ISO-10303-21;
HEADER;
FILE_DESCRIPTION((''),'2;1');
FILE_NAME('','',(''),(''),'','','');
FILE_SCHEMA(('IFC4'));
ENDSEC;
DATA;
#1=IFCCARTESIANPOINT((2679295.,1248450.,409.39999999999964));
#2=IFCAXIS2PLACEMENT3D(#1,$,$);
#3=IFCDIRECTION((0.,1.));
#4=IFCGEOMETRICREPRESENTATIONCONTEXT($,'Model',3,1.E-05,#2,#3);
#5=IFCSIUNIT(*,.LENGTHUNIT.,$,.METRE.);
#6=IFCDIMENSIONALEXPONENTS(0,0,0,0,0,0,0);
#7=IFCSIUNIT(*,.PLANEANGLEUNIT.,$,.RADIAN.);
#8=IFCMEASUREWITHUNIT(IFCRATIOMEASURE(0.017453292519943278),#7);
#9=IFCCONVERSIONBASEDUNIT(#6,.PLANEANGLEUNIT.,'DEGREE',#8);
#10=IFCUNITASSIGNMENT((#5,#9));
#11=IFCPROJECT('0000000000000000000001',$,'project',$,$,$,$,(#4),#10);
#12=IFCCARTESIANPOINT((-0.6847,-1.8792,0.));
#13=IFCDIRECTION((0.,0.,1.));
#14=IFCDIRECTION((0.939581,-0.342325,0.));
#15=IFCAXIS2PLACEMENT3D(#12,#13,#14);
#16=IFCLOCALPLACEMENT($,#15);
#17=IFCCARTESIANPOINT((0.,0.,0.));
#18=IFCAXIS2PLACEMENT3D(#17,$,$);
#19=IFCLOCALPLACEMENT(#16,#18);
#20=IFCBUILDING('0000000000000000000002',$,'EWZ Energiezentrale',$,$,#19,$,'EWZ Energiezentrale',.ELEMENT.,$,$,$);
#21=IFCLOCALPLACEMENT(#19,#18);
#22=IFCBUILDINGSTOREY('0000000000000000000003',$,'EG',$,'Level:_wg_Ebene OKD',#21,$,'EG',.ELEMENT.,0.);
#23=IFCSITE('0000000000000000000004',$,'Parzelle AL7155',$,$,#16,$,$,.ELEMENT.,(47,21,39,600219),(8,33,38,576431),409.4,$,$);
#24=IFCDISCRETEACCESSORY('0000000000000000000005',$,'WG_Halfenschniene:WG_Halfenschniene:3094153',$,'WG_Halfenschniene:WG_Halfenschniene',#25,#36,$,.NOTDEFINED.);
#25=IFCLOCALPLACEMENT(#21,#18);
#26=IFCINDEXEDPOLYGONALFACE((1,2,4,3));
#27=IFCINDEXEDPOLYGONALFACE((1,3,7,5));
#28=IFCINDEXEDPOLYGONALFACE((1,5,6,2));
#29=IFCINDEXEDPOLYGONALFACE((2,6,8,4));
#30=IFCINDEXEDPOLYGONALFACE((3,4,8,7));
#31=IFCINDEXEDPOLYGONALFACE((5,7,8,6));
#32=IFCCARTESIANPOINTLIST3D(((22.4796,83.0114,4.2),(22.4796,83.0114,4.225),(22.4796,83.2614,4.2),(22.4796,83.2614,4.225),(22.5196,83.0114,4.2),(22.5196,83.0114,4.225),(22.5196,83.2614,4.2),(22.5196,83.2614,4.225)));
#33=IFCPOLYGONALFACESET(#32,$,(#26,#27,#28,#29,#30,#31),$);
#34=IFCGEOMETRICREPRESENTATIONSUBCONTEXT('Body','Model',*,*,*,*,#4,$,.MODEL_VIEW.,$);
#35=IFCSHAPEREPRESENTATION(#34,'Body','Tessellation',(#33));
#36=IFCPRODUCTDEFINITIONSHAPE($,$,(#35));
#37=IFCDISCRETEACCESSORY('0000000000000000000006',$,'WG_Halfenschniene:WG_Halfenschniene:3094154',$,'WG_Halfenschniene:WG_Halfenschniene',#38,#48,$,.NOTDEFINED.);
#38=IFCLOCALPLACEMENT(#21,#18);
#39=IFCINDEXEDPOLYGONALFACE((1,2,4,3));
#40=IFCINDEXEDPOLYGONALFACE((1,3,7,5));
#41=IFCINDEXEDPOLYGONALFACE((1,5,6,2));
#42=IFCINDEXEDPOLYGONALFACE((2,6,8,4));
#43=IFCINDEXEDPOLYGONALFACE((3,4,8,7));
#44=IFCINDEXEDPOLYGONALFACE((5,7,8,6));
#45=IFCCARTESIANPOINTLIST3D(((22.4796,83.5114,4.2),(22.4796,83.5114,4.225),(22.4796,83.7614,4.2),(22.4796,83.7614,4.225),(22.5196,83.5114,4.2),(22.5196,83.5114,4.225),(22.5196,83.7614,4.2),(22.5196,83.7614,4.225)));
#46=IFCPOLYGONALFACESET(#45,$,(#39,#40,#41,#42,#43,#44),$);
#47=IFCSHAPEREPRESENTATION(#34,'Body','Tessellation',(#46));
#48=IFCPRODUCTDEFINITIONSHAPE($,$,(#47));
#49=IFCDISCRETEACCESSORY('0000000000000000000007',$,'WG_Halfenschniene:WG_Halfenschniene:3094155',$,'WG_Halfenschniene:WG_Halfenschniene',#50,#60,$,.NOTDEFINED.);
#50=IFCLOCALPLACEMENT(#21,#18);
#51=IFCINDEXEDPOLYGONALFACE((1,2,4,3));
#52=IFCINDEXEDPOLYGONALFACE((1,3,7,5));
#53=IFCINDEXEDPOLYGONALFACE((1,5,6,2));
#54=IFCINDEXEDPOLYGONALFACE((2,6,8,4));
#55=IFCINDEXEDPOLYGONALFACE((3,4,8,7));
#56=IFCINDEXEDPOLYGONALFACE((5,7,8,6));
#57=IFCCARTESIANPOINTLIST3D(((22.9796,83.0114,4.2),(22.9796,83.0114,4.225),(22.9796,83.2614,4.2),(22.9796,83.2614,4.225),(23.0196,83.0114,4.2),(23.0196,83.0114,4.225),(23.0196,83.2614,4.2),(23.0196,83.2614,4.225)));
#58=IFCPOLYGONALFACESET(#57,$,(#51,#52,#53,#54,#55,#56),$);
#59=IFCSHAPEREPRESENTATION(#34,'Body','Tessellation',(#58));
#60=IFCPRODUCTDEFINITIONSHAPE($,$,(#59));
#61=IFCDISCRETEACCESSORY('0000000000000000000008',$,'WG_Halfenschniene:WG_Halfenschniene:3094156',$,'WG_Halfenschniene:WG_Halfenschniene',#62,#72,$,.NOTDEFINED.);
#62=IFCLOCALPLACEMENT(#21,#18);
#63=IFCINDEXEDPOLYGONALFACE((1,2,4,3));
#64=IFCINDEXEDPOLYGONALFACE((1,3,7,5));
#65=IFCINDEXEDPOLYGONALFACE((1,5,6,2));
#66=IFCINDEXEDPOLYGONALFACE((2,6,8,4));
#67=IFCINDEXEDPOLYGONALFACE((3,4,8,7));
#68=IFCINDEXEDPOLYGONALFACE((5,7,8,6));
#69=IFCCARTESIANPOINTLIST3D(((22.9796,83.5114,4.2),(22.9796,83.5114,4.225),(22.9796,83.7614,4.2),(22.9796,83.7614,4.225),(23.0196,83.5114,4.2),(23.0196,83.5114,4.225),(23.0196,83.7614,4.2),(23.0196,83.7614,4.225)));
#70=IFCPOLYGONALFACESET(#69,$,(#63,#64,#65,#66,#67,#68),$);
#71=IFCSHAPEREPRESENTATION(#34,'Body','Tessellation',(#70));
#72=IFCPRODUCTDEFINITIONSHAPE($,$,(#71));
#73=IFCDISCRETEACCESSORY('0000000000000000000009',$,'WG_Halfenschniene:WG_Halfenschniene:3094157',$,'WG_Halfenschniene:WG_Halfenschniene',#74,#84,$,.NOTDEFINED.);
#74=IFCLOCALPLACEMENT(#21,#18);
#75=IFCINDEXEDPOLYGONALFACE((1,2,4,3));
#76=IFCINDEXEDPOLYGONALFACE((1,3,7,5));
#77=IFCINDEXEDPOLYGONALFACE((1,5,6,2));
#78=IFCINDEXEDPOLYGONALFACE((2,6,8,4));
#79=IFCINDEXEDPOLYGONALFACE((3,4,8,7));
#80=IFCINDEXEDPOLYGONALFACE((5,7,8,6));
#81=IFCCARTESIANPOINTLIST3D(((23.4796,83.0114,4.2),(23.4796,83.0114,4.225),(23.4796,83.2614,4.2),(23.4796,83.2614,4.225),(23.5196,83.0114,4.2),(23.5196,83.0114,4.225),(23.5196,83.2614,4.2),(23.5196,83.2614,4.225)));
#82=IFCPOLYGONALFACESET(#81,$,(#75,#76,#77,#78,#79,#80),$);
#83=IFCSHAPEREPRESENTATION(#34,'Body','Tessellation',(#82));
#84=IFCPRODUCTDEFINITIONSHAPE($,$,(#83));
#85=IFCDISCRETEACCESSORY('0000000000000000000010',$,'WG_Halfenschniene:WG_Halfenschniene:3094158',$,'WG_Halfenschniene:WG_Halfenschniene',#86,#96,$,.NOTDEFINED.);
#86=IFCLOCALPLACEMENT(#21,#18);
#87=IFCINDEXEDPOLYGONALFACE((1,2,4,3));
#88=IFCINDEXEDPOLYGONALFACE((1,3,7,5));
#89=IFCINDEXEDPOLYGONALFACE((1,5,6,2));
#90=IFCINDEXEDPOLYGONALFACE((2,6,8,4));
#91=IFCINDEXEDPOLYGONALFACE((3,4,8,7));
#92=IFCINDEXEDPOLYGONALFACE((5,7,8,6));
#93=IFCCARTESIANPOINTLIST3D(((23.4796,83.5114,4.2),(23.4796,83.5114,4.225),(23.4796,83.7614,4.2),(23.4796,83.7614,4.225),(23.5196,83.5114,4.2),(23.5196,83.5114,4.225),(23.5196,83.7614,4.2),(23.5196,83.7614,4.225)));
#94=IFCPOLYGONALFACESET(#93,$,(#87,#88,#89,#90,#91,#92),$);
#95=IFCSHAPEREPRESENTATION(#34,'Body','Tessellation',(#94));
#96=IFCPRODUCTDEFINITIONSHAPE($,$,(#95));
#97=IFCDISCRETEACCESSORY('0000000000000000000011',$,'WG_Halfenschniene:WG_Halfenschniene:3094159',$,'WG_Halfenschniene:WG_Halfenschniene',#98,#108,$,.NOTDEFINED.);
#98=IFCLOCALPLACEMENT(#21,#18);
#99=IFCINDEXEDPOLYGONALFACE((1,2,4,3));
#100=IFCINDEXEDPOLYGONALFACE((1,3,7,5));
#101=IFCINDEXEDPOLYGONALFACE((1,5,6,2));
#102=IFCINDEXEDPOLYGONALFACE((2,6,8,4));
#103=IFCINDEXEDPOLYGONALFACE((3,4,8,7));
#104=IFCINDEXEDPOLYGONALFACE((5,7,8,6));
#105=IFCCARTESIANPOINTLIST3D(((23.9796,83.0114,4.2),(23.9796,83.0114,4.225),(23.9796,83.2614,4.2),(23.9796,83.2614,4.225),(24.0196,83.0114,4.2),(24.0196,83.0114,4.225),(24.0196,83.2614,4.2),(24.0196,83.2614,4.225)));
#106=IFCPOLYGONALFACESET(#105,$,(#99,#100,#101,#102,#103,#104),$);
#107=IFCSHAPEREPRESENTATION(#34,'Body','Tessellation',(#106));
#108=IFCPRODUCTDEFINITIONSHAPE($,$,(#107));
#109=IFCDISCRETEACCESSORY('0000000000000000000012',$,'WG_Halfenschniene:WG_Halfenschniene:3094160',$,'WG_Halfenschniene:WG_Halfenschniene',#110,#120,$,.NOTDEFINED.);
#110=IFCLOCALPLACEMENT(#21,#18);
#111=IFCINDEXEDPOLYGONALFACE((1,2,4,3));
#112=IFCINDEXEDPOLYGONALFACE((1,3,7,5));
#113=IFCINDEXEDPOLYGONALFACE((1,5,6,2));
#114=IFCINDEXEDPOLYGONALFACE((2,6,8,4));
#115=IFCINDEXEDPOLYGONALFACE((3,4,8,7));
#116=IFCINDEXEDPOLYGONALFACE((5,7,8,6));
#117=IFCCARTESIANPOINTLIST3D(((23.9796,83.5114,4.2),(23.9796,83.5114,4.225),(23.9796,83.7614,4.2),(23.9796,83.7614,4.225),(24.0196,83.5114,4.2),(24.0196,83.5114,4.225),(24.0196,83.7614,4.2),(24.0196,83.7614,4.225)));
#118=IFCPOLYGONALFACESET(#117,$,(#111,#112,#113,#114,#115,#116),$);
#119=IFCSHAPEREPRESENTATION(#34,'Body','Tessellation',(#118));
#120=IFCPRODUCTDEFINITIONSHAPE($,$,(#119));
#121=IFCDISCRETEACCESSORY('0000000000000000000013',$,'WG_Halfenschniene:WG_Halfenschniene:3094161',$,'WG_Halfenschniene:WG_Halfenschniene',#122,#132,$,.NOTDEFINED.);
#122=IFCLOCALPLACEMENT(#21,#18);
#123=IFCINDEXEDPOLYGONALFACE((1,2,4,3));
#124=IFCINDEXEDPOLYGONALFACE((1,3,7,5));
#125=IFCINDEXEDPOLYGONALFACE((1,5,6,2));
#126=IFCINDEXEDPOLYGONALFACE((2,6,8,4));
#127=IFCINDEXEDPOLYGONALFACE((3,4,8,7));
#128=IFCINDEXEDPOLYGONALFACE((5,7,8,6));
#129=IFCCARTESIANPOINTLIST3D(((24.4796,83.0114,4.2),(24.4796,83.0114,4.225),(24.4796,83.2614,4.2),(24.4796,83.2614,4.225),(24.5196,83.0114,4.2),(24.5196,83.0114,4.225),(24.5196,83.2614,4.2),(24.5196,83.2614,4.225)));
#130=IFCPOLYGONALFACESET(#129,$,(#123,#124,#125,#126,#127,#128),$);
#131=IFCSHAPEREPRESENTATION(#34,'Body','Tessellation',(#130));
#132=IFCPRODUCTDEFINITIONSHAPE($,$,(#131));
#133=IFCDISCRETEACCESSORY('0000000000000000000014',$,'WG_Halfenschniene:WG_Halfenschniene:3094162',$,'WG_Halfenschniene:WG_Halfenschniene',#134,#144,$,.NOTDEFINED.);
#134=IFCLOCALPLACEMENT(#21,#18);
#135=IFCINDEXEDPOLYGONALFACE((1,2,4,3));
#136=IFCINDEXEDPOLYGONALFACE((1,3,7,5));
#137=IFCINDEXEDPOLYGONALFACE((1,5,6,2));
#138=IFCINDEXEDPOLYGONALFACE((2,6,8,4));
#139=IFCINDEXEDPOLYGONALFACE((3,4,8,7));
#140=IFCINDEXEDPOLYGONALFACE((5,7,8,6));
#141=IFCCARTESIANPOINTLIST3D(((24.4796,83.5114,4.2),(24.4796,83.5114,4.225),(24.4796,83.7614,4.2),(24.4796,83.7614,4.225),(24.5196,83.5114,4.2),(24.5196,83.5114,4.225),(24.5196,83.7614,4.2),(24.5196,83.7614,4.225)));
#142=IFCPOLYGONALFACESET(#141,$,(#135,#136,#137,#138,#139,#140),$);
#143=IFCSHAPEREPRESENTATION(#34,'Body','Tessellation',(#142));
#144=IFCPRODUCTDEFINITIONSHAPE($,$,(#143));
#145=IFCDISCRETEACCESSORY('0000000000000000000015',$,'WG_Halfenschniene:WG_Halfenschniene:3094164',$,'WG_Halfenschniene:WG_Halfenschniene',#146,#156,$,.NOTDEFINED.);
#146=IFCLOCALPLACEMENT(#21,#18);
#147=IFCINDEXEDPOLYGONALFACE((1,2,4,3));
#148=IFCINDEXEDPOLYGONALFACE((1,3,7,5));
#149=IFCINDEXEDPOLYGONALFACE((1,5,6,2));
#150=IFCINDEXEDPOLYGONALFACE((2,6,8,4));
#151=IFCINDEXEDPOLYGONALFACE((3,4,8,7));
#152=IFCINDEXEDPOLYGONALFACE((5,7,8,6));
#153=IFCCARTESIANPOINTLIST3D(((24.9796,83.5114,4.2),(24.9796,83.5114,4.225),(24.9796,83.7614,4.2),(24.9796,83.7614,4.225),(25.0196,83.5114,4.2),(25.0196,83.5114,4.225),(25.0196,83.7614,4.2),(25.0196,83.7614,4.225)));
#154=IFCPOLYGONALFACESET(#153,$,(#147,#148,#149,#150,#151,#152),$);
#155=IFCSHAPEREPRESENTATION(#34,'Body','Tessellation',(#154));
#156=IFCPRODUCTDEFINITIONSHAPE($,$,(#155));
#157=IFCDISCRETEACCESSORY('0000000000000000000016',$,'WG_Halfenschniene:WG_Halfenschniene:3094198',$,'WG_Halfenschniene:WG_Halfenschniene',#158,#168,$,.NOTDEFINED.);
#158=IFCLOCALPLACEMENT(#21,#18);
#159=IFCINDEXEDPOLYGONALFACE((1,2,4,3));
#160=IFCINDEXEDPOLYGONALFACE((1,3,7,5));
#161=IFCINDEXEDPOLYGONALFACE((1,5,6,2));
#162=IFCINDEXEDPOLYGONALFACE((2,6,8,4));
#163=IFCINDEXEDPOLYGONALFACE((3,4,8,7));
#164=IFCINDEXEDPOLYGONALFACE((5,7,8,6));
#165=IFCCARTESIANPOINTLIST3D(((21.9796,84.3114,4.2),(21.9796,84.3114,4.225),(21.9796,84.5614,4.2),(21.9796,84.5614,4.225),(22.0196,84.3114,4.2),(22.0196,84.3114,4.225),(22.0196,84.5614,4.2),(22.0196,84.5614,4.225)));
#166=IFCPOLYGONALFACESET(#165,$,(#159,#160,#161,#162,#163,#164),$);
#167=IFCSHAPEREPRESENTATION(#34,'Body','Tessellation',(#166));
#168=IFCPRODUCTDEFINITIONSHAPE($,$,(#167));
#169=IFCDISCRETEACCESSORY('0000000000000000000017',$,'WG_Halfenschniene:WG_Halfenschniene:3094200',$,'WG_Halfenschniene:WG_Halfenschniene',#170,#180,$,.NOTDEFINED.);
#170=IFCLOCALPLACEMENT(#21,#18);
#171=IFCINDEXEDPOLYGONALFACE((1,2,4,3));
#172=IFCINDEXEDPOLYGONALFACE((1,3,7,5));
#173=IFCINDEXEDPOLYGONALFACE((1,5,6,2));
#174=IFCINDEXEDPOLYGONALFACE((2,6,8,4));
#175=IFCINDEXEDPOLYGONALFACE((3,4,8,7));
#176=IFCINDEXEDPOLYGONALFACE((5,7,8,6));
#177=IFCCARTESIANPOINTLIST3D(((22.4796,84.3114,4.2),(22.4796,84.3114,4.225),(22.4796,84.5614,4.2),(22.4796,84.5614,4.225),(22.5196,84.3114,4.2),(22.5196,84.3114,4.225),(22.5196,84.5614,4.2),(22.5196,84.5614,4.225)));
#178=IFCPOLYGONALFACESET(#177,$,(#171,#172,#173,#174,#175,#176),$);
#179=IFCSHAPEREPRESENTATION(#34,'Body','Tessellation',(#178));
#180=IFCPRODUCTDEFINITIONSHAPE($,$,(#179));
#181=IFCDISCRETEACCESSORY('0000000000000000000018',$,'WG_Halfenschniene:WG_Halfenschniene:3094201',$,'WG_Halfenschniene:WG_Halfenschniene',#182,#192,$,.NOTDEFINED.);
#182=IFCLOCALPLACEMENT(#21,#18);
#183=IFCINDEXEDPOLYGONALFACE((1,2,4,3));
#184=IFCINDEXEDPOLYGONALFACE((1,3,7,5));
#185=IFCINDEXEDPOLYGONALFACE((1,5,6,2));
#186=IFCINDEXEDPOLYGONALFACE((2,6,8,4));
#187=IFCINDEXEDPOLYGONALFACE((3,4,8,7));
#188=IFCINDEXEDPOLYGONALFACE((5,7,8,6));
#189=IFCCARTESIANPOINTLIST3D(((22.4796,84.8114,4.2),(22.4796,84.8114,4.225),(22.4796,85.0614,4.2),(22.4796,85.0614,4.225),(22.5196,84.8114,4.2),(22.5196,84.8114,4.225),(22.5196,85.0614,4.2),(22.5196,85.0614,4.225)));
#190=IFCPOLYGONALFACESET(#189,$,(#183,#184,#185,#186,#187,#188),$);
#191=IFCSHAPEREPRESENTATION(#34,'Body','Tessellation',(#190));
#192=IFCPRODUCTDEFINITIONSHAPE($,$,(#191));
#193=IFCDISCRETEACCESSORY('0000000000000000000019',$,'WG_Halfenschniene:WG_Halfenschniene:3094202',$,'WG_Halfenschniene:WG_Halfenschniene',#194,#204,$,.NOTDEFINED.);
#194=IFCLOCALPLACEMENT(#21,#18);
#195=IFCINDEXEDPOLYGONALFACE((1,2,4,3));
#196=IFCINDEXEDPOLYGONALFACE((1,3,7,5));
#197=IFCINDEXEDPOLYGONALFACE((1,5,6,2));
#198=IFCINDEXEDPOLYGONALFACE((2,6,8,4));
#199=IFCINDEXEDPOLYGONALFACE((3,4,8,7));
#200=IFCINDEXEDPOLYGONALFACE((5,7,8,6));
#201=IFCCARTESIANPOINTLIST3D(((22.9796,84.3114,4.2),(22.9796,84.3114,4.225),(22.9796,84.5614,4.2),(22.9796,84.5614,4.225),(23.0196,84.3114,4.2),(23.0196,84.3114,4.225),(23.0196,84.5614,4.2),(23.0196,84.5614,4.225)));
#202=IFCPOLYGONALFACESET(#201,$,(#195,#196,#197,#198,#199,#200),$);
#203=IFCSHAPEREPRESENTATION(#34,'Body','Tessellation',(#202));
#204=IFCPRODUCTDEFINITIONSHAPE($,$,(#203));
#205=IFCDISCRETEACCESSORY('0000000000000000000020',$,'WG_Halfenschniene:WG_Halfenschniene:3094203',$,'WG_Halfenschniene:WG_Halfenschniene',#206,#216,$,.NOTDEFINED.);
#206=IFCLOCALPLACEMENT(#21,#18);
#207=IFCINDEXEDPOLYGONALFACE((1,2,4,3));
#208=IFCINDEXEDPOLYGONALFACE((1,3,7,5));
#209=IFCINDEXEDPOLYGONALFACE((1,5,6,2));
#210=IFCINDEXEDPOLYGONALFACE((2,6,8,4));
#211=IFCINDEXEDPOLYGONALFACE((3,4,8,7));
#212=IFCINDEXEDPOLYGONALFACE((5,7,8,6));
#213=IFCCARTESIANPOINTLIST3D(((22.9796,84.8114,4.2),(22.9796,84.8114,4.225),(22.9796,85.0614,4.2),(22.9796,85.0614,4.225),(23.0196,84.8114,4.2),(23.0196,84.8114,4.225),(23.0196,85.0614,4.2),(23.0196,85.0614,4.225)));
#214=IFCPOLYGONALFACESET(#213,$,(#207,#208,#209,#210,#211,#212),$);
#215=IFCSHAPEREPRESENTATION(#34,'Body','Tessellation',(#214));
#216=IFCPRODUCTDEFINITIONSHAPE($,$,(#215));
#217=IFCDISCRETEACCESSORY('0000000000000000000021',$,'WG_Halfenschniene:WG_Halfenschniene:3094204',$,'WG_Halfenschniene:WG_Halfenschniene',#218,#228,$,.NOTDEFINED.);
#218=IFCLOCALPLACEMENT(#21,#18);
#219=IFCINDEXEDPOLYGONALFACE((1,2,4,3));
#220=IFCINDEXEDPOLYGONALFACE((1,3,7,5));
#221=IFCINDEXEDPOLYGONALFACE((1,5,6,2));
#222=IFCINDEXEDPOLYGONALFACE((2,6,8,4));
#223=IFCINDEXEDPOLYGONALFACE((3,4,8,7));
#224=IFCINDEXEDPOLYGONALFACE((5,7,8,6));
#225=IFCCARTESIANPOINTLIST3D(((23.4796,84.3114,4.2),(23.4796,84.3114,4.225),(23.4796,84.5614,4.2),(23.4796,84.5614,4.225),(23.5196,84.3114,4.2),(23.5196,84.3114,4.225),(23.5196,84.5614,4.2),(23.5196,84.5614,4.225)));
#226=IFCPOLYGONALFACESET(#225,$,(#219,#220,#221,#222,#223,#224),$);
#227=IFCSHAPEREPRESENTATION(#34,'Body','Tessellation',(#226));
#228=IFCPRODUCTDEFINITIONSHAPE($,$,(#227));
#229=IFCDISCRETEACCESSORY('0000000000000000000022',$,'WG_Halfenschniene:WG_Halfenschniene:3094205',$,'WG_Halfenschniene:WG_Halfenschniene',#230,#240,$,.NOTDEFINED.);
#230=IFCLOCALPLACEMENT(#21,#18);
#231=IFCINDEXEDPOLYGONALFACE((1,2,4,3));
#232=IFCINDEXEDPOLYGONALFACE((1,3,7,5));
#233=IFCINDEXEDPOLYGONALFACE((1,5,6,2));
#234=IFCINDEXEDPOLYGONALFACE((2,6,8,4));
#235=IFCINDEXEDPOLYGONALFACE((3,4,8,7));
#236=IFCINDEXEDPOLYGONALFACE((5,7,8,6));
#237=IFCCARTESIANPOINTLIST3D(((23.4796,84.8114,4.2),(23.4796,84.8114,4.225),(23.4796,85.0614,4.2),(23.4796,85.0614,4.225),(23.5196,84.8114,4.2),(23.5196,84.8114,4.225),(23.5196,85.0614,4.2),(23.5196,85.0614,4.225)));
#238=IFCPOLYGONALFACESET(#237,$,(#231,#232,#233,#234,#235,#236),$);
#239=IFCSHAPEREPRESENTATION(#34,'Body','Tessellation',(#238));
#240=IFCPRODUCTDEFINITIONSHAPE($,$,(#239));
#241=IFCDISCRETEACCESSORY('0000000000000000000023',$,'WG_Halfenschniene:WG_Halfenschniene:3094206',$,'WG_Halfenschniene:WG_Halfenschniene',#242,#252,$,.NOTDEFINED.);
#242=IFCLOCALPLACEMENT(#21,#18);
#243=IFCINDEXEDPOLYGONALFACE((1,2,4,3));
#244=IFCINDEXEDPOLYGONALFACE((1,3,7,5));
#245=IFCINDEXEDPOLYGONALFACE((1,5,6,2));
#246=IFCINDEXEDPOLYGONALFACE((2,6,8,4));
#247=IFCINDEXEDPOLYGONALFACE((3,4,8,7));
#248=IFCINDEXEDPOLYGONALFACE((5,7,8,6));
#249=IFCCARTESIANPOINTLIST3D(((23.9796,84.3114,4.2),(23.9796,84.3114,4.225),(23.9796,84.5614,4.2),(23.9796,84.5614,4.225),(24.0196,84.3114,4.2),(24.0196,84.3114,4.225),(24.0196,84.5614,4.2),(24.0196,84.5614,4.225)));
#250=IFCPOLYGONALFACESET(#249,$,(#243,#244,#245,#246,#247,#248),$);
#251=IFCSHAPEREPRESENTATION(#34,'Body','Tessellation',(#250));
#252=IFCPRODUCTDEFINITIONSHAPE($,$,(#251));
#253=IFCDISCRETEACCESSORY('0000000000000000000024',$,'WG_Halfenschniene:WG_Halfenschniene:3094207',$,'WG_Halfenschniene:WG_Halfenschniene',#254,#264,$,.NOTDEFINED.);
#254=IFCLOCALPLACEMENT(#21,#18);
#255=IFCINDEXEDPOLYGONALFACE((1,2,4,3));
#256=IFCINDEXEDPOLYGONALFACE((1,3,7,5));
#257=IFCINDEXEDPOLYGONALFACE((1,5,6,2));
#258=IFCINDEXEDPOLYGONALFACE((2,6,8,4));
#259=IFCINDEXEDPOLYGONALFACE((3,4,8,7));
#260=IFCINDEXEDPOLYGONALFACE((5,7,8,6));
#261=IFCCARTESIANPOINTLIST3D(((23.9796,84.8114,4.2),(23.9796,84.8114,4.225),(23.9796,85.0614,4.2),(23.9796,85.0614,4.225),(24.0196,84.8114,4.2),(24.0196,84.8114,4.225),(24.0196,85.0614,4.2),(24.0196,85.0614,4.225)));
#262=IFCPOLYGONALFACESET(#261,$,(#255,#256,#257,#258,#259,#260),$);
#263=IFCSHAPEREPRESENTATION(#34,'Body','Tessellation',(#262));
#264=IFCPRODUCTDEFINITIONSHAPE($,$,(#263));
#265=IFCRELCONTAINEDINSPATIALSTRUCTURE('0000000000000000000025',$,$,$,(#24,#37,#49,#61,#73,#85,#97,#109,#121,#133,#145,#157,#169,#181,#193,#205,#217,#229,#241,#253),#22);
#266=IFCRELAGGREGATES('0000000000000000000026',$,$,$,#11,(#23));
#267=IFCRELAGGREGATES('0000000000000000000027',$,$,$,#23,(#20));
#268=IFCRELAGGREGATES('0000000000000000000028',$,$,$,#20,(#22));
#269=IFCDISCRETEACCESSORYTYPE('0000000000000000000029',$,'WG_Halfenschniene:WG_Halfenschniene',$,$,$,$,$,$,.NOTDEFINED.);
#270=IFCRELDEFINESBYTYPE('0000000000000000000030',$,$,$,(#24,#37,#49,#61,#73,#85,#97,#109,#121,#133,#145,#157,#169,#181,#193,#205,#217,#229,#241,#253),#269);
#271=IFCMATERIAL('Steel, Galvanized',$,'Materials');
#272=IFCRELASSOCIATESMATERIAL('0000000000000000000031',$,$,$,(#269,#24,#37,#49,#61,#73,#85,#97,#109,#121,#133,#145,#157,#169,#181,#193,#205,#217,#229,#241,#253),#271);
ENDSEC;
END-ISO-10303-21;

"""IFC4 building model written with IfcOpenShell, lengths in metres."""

from ifc_helpers import new_model, entity, si_unit, converted_unit, direction, frame, origin, place, context, subcontext, project, spatial, indexed_curve, outline, extrude, source, transform, mapped, material, type_object, element, save


model = new_model("IFC4")

# Units and contexts
model_context = context("Model", 3, precision=1e-05, world=frame((2679295.0, 1248450.0, 409.39999999999964)), true_north=direction((0.0, 1.0)))
body_context = subcontext(model_context, "Body", "Model", "MODEL_VIEW")
ifc_project = project(units=[si_unit("LENGTHUNIT", "METRE"), converted_unit("PLANEANGLEUNIT", "DEGREE", entity("IfcRatioMeasure", 0.017453292519943278), si_unit("PLANEANGLEUNIT", "RADIAN"), dimensions=[0, 0, 0, 0, 0, 0, 0])], contexts=[model_context])

# Site, building, storey
site_placement = place(None, frame((-0.6847, -1.8792, 0.0), z_axis=(0.0, 0.0, 1.0), x_axis=(0.939581, -0.342325, 0.0)))
site = spatial("IfcSite", under=ifc_project, at=site_placement, Name="Parzelle AL7155", CompositionType="ELEMENT", RefLatitude=(47, 21, 39, 600219), RefLongitude=(8, 33, 38, 576431), RefElevation=409.4)
building_placement = place(site_placement, origin())
building = spatial("IfcBuilding", under=site, at=building_placement, Name="EWZ Energiezentrale", LongName="EWZ Energiezentrale", CompositionType="ELEMENT")
storey_placement = place(building_placement, origin())
storey = spatial("IfcBuildingStorey", under=building, at=storey_placement, Name="EG", ObjectType="Level:_wg_Ebene OKD", LongName="EG", CompositionType="ELEMENT", Elevation=0.0)

# Discrete accessories
ifc_material = material(Name="Steel, Galvanized", Category="Materials")
discrete_accessory_type = type_object("IfcDiscreteAccessoryType", Name="WG_Halfenschniene:WG_Halfenschniene", PredefinedType="NOTDEFINED", material=ifc_material)
shared_shape = source(origin(), body_context, "Body", "SweptSolid", [
    extrude(outline(indexed_curve([(-0.125, -0.02), (0.125, -0.02), (0.125, 0.02), (-0.125, 0.02), (-0.125, -0.02)], self_intersect=False)), frame((0.125, 0.0, -0.0125)), (0.0, 0.0, 1.0), 0.025),
])
for number, where, z_axis, x_axis, name in (
    (1, (22.4996, 83.0114, 4.2125), (0.0, 0.0, -1.0), (0.0, 1.0, 0.0), "WG_Halfenschniene:WG_Halfenschniene:3094153"),
    (2, (22.4996, 83.5114, 4.2125), (0.0, 0.0, -1.0), (0.0, 1.0, 0.0), "WG_Halfenschniene:WG_Halfenschniene:3094154"),
    (3, (22.9996, 83.0114, 4.2125), (0.0, 0.0, -1.0), (0.0, 1.0, 0.0), "WG_Halfenschniene:WG_Halfenschniene:3094155"),
    (4, (22.9996, 83.5114, 4.2125), (0.0, 0.0, -1.0), (0.0, 1.0, 0.0), "WG_Halfenschniene:WG_Halfenschniene:3094156"),
    (5, (23.4996, 83.0114, 4.2125), (0.0, 0.0, -1.0), (0.0, 1.0, 0.0), "WG_Halfenschniene:WG_Halfenschniene:3094157"),
    (6, (23.4996, 83.5114, 4.2125), (0.0, 0.0, -1.0), (0.0, 1.0, 0.0), "WG_Halfenschniene:WG_Halfenschniene:3094158"),
    (7, (23.9996, 83.0114, 4.2125), (0.0, 0.0, -1.0), (0.0, 1.0, 0.0), "WG_Halfenschniene:WG_Halfenschniene:3094159"),
    (8, (23.9996, 83.5114, 4.2125), (0.0, 0.0, -1.0), (0.0, 1.0, 0.0), "WG_Halfenschniene:WG_Halfenschniene:3094160"),
    (9, (24.4996, 83.0114, 4.2125), (0.0, 0.0, -1.0), (0.0, 1.0, 0.0), "WG_Halfenschniene:WG_Halfenschniene:3094161"),
    (10, (24.4996, 83.5114, 4.2125), (0.0, 0.0, -1.0), (0.0, 1.0, 0.0), "WG_Halfenschniene:WG_Halfenschniene:3094162"),
    (11, (24.9996, 83.5114, 4.2125), (0.0, 0.0, -1.0), (0.0, 1.0, 0.0), "WG_Halfenschniene:WG_Halfenschniene:3094164"),
    (12, (21.9996, 84.3114, 4.2125), (0.0, 0.0, -1.0), (0.0, 1.0, 0.0), "WG_Halfenschniene:WG_Halfenschniene:3094198"),
    (13, (22.4996, 84.3114, 4.2125), (0.0, 0.0, -1.0), (0.0, 1.0, 0.0), "WG_Halfenschniene:WG_Halfenschniene:3094200"),
    (14, (22.4996, 84.8114, 4.2125), (0.0, 0.0, -1.0), (0.0, 1.0, 0.0), "WG_Halfenschniene:WG_Halfenschniene:3094201"),
    (15, (22.9996, 84.3114, 4.2125), (0.0, 0.0, -1.0), (0.0, 1.0, 0.0), "WG_Halfenschniene:WG_Halfenschniene:3094202"),
    (16, (22.9996, 84.8114, 4.2125), (0.0, 0.0, -1.0), (0.0, 1.0, 0.0), "WG_Halfenschniene:WG_Halfenschniene:3094203"),
    (17, (23.4996, 84.3114, 4.2125), (0.0, 0.0, -1.0), (0.0, 1.0, 0.0), "WG_Halfenschniene:WG_Halfenschniene:3094204"),
    (18, (23.4996, 84.8114, 4.2125), (0.0, 0.0, -1.0), (0.0, 1.0, 0.0), "WG_Halfenschniene:WG_Halfenschniene:3094205"),
    (19, (23.9996, 84.3114, 4.2125), (0.0, 0.0, -1.0), (0.0, 1.0, 0.0), "WG_Halfenschniene:WG_Halfenschniene:3094206"),
    (20, (23.9996, 84.8114, 4.2125), (0.0, 0.0, -1.0), (0.0, 1.0, 0.0), "WG_Halfenschniene:WG_Halfenschniene:3094207"),
):
    element("IfcDiscreteAccessory", number, at=place(storey_placement, frame(where, z_axis=z_axis, x_axis=x_axis)), inside=storey, type_object=discrete_accessory_type, material=ifc_material, Name=name, ObjectType="WG_Halfenschniene:WG_Halfenschniene", PredefinedType="NOTDEFINED", context=body_context, shape_type="MappedRepresentation", body=[
        mapped(shared_shape, transform((0.0, 0.0, 0.0), scale=1.0)),
    ])

save(model, "model.ifc")
